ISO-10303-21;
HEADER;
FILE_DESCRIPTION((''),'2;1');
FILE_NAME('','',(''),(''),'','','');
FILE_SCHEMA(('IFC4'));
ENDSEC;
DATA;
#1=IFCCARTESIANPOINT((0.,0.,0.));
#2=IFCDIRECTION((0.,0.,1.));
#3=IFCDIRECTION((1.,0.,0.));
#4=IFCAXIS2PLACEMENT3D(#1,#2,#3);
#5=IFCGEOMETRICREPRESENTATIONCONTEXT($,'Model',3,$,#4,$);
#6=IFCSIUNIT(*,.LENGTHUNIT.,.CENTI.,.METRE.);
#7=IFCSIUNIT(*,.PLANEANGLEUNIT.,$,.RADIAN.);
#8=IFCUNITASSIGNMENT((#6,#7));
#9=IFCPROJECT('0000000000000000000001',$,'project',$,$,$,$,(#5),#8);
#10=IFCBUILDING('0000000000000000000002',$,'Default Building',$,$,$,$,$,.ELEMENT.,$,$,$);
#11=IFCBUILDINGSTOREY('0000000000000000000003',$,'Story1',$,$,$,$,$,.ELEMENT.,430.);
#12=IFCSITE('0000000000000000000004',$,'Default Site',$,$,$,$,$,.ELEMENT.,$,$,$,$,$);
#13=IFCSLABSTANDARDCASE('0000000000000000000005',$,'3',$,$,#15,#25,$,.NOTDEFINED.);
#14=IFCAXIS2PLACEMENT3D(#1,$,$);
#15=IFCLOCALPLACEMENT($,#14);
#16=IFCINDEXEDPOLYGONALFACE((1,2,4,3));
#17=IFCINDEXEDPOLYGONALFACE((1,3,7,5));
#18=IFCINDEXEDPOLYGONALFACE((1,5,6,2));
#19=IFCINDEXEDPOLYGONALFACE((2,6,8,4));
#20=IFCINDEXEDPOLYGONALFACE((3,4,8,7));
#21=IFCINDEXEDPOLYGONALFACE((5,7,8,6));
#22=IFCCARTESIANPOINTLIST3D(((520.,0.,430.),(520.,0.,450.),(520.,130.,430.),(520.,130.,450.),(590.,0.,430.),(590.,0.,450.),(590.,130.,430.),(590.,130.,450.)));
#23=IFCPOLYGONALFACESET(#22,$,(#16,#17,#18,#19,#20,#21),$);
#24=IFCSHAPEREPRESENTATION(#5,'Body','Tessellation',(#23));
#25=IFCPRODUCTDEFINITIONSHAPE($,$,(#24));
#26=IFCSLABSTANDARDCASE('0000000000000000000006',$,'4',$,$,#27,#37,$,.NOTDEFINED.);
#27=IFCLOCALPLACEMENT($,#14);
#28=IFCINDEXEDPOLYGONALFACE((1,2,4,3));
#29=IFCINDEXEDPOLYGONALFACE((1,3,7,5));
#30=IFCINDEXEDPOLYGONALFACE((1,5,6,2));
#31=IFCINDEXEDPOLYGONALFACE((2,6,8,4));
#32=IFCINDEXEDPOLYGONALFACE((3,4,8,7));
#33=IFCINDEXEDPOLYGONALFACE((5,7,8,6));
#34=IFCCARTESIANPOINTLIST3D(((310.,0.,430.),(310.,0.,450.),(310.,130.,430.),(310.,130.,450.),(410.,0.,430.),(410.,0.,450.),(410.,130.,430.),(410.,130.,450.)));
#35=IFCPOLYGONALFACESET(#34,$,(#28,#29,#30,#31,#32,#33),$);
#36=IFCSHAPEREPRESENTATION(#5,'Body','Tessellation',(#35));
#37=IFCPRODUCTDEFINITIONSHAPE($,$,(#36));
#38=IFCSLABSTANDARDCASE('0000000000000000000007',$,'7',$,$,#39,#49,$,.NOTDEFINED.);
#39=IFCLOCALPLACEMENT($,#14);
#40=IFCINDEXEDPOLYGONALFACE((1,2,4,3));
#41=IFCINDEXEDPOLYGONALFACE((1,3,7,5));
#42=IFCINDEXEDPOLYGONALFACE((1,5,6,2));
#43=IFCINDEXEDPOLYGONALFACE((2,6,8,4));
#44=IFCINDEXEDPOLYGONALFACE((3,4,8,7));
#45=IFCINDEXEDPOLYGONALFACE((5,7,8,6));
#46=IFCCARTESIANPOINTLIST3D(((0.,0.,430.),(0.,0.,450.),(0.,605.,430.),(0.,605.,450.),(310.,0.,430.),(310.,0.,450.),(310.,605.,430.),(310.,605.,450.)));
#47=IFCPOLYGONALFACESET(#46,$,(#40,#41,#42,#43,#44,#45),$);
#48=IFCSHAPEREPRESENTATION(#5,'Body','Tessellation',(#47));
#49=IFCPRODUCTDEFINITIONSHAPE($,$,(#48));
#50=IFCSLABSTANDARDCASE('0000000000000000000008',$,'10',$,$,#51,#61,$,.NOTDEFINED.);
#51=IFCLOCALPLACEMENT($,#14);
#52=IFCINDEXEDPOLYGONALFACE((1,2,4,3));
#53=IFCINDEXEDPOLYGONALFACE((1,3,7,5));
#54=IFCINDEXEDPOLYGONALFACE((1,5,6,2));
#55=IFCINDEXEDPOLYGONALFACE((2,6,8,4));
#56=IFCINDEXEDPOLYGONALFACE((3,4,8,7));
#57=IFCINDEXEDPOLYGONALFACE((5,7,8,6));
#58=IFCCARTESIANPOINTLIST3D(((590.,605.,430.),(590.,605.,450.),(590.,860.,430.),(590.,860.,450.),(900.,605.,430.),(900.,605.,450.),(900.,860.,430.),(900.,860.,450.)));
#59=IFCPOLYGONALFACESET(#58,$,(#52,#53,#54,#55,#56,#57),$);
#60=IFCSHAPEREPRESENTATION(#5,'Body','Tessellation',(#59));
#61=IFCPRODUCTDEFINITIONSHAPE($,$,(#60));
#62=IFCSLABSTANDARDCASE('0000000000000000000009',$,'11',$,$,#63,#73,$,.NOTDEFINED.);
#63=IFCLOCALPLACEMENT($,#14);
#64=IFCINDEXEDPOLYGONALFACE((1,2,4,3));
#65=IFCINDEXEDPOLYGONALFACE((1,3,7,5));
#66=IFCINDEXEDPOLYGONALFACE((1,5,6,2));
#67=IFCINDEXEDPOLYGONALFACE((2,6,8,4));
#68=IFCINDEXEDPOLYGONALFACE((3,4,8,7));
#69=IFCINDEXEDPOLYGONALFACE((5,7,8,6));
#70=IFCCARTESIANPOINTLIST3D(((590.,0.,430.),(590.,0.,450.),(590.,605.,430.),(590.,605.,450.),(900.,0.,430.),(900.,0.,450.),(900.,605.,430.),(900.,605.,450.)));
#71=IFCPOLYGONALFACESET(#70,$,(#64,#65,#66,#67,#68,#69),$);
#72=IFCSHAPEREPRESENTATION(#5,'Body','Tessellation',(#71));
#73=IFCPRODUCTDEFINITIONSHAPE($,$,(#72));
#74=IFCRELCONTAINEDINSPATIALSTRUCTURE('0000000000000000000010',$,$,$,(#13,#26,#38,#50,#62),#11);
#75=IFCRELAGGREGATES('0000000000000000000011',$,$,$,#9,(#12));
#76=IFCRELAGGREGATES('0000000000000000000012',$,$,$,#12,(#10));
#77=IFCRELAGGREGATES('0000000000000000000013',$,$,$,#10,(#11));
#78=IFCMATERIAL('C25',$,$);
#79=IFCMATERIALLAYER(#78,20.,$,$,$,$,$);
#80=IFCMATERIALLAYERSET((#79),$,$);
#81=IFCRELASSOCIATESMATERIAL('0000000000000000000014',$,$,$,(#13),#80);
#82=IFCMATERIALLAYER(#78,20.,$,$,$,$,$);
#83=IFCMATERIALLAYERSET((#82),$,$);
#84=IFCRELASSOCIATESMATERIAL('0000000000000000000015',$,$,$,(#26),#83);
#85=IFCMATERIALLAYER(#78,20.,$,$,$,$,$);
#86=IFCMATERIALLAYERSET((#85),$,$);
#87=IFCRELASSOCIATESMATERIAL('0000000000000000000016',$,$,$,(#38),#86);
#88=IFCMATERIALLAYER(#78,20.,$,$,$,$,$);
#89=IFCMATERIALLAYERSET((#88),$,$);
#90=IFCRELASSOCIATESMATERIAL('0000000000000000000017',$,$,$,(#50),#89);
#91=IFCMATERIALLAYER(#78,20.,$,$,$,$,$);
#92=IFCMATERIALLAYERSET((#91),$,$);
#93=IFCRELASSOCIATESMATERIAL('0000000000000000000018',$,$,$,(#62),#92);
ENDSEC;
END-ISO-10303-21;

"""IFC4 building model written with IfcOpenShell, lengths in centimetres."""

from ifc_helpers import new_model, si_unit, frame, origin_with_axes, place, context, project, spatial, polyline, outline, extrude, material, layer, layer_set, layer_usage, element, save


model = new_model("IFC4")

# Units and contexts
model_context = context("Model", 3, world=origin_with_axes())
ifc_project = project(units=[si_unit("LENGTHUNIT", "METRE", prefix="CENTI"), si_unit("PLANEANGLEUNIT", "RADIAN")], contexts=[model_context])

# Site, building, storey
site = spatial("IfcSite", under=ifc_project, Name="Default Site", CompositionType="ELEMENT")
building = spatial("IfcBuilding", under=site, Name="Default Building", CompositionType="ELEMENT")
storey = spatial("IfcBuildingStorey", under=building, Name="Story1", CompositionType="ELEMENT", Elevation=430.0)

# Shared definitions
ifc_material = material(Name="C25")

# Slabs
ifc_layer_1 = layer(ifc_material, 20.0)
ifc_layer_set_1 = layer_set([ifc_layer_1])
ifc_layer_usage_1 = layer_usage(ifc_layer_set_1, "AXIS2", "POSITIVE", -20.0)
slab_1_placement = place(None, frame((520.0, 0.0, 430.0), z_axis=(0.0, 0.0, 1.0), x_axis=(1.0, 0.0, 0.0)))
element("IfcSlabStandardCase", 1, at=slab_1_placement, inside=storey, material=ifc_layer_usage_1, Name="3", PredefinedType="NOTDEFINED", context=model_context, shape_type="SweptSolid", body=[
    extrude(outline(polyline([(0.0, 0.0), (70.0, 0.0), (70.0, 130.0), (0.0, 130.0), (0.0, 0.0)])), origin_with_axes(), (0.0, 0.0, 1.0), 20.0),
])
ifc_layer_2 = layer(ifc_material, 20.0)
ifc_layer_set_2 = layer_set([ifc_layer_2])
ifc_layer_usage_2 = layer_usage(ifc_layer_set_2, "AXIS2", "POSITIVE", -20.0)
slab_2_placement = place(None, frame((310.0, 0.0, 430.0), z_axis=(0.0, 0.0, 1.0), x_axis=(1.0, 0.0, 0.0)))
element("IfcSlabStandardCase", 2, at=slab_2_placement, inside=storey, material=ifc_layer_usage_2, Name="4", PredefinedType="NOTDEFINED", context=model_context, shape_type="SweptSolid", body=[
    extrude(outline(polyline([(0.0, 0.0), (100.0, 0.0), (100.0, 130.0), (0.0, 130.0), (0.0, 0.0)])), origin_with_axes(), (0.0, 0.0, 1.0), 20.0),
])
ifc_layer_3 = layer(ifc_material, 20.0)
ifc_layer_set_3 = layer_set([ifc_layer_3])
ifc_layer_usage_3 = layer_usage(ifc_layer_set_3, "AXIS2", "POSITIVE", -20.0)
slab_3_placement = place(None, frame((0.0, 605.0, 430.0), z_axis=(0.0, 0.0, 1.0), x_axis=(0.0, -1.0, 0.0)))
element("IfcSlabStandardCase", 3, at=slab_3_placement, inside=storey, material=ifc_layer_usage_3, Name="7", PredefinedType="NOTDEFINED", context=model_context, shape_type="SweptSolid", body=[
    extrude(outline(polyline([(0.0, 0.0), (605.0, 0.0), (605.0, 310.0), (0.0, 310.0), (0.0, 0.0)])), origin_with_axes(), (0.0, 0.0, 1.0), 20.0),
])
ifc_layer_4 = layer(ifc_material, 20.0)
ifc_layer_set_4 = layer_set([ifc_layer_4])
ifc_layer_usage_4 = layer_usage(ifc_layer_set_4, "AXIS2", "POSITIVE", -20.0)
slab_4_placement = place(None, frame((590.0, 605.0, 430.0), z_axis=(0.0, 0.0, 1.0), x_axis=(1.0, 0.0, 0.0)))
element("IfcSlabStandardCase", 4, at=slab_4_placement, inside=storey, material=ifc_layer_usage_4, Name="10", PredefinedType="NOTDEFINED", context=model_context, shape_type="SweptSolid", body=[
    extrude(outline(polyline([(0.0, 0.0), (310.0, 0.0), (310.0, 255.0), (0.0, 255.0), (0.0, 0.0)])), origin_with_axes(), (0.0, 0.0, 1.0), 20.0),
])
ifc_layer_5 = layer(ifc_material, 20.0)
ifc_layer_set_5 = layer_set([ifc_layer_5])
ifc_layer_usage_5 = layer_usage(ifc_layer_set_5, "AXIS2", "POSITIVE", -20.0)
slab_5_placement = place(None, frame((590.0, 0.0, 430.0), z_axis=(0.0, 0.0, 1.0), x_axis=(1.0, 0.0, 0.0)))
element("IfcSlabStandardCase", 5, at=slab_5_placement, inside=storey, material=ifc_layer_usage_5, Name="11", PredefinedType="NOTDEFINED", context=model_context, shape_type="SweptSolid", body=[
    extrude(outline(polyline([(0.0, 0.0), (310.0, 0.0), (310.0, 605.0), (0.0, 605.0), (0.0, 0.0)])), origin_with_axes(), (0.0, 0.0, 1.0), 20.0),
])

save(model, "model.ifc")
